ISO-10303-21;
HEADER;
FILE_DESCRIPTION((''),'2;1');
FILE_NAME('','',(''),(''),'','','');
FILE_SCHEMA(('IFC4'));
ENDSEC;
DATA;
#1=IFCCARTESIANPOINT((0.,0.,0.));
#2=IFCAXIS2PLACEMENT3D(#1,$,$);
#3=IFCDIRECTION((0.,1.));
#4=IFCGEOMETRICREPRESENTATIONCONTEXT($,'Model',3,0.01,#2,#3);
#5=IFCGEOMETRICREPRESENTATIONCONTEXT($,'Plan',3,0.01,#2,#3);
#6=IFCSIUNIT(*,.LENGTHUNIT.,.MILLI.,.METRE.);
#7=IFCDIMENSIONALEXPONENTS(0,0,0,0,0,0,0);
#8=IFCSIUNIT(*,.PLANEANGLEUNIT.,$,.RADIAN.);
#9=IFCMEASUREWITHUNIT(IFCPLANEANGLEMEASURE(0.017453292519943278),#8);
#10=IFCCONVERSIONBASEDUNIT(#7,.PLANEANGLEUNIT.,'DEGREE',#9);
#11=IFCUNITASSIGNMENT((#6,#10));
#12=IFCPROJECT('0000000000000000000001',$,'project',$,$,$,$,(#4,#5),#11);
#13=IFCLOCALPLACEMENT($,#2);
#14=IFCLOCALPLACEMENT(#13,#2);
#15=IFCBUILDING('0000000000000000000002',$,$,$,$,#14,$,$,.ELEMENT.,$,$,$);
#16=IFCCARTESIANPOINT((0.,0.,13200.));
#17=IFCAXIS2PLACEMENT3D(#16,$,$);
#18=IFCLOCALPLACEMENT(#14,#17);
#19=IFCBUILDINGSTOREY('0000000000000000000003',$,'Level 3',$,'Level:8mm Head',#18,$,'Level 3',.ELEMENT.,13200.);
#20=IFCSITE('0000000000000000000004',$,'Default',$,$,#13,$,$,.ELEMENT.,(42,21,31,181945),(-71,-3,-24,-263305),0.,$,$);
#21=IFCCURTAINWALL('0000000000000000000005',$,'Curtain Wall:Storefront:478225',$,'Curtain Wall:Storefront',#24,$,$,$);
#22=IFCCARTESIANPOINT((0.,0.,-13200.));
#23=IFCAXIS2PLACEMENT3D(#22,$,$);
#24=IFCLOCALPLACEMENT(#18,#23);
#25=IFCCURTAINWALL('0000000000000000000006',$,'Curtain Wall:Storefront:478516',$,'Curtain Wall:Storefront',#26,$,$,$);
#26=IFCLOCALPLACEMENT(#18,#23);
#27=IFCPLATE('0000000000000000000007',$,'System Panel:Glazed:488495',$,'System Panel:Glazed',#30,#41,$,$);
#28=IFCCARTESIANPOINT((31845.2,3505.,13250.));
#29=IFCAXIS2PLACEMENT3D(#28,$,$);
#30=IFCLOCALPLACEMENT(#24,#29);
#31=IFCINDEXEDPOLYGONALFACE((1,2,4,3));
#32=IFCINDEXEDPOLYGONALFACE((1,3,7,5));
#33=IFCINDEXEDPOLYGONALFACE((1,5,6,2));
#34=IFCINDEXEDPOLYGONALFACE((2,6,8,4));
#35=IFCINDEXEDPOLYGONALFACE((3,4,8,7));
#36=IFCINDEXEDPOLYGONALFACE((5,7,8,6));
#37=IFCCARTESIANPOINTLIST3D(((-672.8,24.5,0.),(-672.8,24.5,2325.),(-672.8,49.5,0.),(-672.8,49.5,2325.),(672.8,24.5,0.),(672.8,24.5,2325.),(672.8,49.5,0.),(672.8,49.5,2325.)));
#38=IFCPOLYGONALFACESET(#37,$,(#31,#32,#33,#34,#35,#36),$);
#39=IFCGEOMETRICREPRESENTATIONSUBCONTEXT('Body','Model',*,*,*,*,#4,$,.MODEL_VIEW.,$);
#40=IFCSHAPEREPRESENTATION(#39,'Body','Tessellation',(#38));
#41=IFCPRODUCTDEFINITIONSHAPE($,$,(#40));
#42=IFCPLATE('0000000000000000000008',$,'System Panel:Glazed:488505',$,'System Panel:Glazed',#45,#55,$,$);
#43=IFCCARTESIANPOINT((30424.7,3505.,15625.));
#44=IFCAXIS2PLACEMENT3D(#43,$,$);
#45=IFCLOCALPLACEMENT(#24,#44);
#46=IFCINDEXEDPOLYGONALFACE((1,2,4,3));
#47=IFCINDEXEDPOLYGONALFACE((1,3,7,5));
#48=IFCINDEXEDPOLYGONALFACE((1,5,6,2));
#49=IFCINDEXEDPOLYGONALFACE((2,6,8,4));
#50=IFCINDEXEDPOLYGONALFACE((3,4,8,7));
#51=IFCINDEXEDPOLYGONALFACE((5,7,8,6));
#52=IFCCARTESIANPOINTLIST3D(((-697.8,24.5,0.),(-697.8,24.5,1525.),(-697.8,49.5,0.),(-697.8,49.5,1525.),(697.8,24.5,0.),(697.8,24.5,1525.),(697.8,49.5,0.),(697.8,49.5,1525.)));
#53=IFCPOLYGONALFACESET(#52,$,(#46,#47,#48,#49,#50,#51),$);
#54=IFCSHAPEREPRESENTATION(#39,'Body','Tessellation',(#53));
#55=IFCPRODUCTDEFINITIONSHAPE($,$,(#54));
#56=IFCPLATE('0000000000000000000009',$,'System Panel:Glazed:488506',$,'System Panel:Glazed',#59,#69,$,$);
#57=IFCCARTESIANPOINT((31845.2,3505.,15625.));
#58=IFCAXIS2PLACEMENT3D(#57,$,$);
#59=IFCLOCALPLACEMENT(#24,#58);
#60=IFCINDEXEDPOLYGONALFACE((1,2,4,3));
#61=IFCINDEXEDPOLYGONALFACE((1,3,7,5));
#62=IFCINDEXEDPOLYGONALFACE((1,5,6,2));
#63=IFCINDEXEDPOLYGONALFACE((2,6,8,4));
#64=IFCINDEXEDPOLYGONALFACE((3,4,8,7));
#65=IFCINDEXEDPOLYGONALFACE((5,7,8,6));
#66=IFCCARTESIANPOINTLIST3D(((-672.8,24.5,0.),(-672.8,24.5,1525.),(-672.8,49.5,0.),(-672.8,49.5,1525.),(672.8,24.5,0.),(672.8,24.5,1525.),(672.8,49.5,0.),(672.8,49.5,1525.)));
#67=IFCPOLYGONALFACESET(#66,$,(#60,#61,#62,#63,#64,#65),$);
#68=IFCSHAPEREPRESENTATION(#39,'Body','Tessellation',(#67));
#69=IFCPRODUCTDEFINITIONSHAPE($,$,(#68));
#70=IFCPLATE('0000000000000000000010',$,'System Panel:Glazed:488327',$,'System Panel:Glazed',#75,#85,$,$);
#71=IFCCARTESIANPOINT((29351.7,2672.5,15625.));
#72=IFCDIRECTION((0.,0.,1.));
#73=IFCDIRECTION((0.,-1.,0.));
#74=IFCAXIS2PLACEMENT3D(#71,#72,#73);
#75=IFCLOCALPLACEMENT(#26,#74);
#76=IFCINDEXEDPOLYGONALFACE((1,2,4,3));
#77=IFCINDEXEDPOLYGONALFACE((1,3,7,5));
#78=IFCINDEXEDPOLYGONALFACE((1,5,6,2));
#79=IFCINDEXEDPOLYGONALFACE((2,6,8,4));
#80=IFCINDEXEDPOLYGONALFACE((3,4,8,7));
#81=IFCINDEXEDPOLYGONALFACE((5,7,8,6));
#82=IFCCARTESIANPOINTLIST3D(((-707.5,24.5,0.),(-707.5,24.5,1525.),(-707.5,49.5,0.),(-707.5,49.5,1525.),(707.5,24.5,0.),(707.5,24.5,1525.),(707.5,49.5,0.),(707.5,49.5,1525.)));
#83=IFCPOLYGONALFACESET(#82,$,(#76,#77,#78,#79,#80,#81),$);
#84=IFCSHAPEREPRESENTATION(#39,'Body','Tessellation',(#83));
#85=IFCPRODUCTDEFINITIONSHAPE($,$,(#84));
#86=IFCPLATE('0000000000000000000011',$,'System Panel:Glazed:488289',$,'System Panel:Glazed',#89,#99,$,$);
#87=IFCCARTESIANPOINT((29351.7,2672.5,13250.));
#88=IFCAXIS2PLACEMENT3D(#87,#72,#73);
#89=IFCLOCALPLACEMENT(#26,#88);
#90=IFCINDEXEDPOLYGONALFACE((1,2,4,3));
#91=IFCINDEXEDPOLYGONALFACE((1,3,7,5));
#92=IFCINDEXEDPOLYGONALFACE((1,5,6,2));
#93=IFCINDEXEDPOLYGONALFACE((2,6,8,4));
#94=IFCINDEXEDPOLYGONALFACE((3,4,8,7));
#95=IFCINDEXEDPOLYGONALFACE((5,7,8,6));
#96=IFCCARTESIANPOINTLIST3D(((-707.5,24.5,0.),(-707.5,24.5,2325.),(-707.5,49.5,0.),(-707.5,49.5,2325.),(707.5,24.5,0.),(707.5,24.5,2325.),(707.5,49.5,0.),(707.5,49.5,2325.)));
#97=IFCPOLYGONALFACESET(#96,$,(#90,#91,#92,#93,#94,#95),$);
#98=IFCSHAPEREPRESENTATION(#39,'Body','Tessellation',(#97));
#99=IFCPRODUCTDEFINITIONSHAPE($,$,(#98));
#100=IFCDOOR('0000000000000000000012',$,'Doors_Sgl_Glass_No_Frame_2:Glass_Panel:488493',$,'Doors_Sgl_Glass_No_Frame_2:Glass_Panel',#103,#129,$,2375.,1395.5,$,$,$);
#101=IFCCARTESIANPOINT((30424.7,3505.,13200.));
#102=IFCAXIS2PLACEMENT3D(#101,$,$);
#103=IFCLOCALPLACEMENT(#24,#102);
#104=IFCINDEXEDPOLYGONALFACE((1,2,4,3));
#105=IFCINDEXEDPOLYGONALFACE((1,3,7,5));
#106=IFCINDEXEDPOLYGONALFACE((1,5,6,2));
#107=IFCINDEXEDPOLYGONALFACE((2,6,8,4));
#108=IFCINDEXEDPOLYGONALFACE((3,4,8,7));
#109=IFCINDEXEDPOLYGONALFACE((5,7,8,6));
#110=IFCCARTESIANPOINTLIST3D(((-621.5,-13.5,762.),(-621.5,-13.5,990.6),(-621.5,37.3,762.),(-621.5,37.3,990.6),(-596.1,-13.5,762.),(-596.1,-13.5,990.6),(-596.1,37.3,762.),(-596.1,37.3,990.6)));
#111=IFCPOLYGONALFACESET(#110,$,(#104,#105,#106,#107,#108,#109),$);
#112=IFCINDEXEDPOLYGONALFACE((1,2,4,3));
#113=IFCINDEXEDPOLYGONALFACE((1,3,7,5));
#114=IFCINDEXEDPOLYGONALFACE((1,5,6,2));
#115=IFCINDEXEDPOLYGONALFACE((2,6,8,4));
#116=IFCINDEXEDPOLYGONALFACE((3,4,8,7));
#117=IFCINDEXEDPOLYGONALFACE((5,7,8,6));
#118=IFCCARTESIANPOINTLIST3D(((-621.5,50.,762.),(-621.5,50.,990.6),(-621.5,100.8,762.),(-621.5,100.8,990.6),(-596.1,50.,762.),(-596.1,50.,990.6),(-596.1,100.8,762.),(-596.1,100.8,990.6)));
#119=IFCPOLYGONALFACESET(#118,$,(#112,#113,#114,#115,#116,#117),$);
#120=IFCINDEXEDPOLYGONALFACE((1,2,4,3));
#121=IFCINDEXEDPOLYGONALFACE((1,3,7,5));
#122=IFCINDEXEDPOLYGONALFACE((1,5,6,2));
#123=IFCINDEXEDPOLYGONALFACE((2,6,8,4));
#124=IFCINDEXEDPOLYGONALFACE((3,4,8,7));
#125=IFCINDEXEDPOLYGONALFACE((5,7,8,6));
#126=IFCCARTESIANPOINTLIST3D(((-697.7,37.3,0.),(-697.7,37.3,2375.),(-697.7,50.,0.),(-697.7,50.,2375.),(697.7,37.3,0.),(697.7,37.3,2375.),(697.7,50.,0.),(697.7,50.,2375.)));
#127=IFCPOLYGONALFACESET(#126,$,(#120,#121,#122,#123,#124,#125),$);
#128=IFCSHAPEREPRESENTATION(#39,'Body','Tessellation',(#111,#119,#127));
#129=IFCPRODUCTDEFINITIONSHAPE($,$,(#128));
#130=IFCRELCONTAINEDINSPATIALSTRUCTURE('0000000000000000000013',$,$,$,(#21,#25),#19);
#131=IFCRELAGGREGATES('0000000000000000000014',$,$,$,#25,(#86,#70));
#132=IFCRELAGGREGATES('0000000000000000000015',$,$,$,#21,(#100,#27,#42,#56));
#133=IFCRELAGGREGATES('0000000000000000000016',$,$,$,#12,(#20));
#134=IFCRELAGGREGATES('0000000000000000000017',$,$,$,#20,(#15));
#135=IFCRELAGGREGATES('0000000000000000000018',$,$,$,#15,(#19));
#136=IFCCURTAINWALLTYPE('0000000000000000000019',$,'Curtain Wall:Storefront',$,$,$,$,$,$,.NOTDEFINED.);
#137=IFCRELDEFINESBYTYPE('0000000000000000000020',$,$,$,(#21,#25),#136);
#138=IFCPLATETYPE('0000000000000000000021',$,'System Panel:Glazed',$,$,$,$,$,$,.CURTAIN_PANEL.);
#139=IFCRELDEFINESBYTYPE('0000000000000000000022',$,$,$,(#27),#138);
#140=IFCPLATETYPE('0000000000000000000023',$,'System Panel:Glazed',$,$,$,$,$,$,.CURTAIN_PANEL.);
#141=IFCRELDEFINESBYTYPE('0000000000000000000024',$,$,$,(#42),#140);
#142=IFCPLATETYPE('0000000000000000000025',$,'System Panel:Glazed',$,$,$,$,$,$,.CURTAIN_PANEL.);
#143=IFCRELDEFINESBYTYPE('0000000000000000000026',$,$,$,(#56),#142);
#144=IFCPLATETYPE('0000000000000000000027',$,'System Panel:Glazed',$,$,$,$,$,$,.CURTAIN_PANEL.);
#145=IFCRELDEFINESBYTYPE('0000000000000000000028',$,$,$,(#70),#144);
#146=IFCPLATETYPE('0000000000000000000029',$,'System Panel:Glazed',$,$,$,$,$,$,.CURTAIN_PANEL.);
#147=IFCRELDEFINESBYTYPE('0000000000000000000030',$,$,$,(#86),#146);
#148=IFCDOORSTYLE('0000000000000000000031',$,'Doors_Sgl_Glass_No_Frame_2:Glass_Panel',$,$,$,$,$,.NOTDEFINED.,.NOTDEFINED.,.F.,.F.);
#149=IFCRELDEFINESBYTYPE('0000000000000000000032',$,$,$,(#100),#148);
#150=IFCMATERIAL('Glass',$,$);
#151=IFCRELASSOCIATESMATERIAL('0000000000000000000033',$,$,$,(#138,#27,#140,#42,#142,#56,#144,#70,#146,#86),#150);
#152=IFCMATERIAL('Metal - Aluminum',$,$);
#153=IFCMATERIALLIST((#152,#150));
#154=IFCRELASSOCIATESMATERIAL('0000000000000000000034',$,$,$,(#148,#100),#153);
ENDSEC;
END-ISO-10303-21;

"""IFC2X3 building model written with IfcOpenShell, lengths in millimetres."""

from ifc_helpers import new_model, entity, si_unit, converted_unit, direction, frame, frame_2d, origin, origin_2d_with_axis, place, context, subcontext, project, spatial, rectangle, extrude, source, transform, mapped, material, material_list, type_object, type_shapes, element, aggregate, save


model = new_model("IFC2X3")

# Units and contexts
model_context = context("Model", 3, precision=0.01, world=origin(), true_north=direction((0.0, 1.0)))
plan_context = context("Plan", 3, precision=0.01, world=origin(), true_north=direction((0.0, 1.0)))
body_context = subcontext(model_context, "Body", "Model", "MODEL_VIEW")
ifc_project = project(units=[si_unit("LENGTHUNIT", "METRE", prefix="MILLI"), converted_unit("PLANEANGLEUNIT", "DEGREE", entity("IfcPlaneAngleMeasure", 0.017453292519943278), si_unit("PLANEANGLEUNIT", "RADIAN"), dimensions=[0, 0, 0, 0, 0, 0, 0])], contexts=[model_context, plan_context])

# Site, building, storey
site_placement = place(None, origin())
site = spatial("IfcSite", under=ifc_project, at=site_placement, Name="Default", CompositionType="ELEMENT", RefLatitude=(42, 21, 31, 181945), RefLongitude=(-71, -3, -24, -263305), RefElevation=0.0)
building_placement = place(site_placement, origin())
building = spatial("IfcBuilding", under=site, at=building_placement, CompositionType="ELEMENT")
storey_placement = place(building_placement, frame((0.0, 0.0, 13200.0)))
storey = spatial("IfcBuildingStorey", under=building, at=storey_placement, Name="Level 3", ObjectType="Level:8mm Head", LongName="Level 3", CompositionType="ELEMENT", Elevation=13200.0)

# Curtain walls
curtain_wall_type = type_object("IfcCurtainWallType", Name="Curtain Wall:Storefront", PredefinedType="NOTDEFINED")
curtain_wall_1_placement = place(storey_placement, frame((0.0, 0.0, -13200.0)))
curtain_wall_1 = element("IfcCurtainWall", 1, at=curtain_wall_1_placement, inside=storey, type_object=curtain_wall_type, Name="Curtain Wall:Storefront:478225", ObjectType="Curtain Wall:Storefront")
curtain_wall_2_placement = place(storey_placement, frame((0.0, 0.0, -13200.0)))
curtain_wall_2 = element("IfcCurtainWall", 2, at=curtain_wall_2_placement, inside=storey, type_object=curtain_wall_type, Name="Curtain Wall:Storefront:478516", ObjectType="Curtain Wall:Storefront")

# Plates
ifc_material_1 = material(Name="Glass")
plate_type_1 = type_object("IfcPlateType", Name="System Panel:Glazed", PredefinedType="CURTAIN_PANEL", material=ifc_material_1)
shared_shape_1 = source(origin(), body_context, "Body", "SweptSolid", [
    extrude(rectangle(XDim=25.0, YDim=1345.5, at=origin_2d_with_axis()), frame((0.0, 37.0, 0.0), z_axis=(0.0, 0.0, 1.0), x_axis=(0.0, 1.0, 0.0)), (0.0, 0.0, 1.0), 2325.0),
])
type_shapes(plate_type_1, [shared_shape_1])
plate_1_placement = place(curtain_wall_1_placement, frame((31845.2, 3505.0, 13250.0)))
plate_1 = element("IfcPlate", 3, at=plate_1_placement, type_object=plate_type_1, material=ifc_material_1, Name="System Panel:Glazed:488495", ObjectType="System Panel:Glazed", context=body_context, shape_type="MappedRepresentation", body=[
    mapped(shared_shape_1, transform((0.0, 0.0, 0.0), scale=1.0)),
])
plate_type_2 = type_object("IfcPlateType", Name="System Panel:Glazed", PredefinedType="CURTAIN_PANEL", material=ifc_material_1)
shared_shape_2 = source(origin(), body_context, "Body", "SweptSolid", [
    extrude(rectangle(XDim=25.0, YDim=1395.5, at=origin_2d_with_axis()), frame((0.0, 37.0, 0.0), z_axis=(0.0, 0.0, 1.0), x_axis=(0.0, 1.0, 0.0)), (0.0, 0.0, 1.0), 1525.0),
])
type_shapes(plate_type_2, [shared_shape_2])
plate_2_placement = place(curtain_wall_1_placement, frame((30424.7, 3505.0, 15625.0)))
plate_2 = element("IfcPlate", 4, at=plate_2_placement, type_object=plate_type_2, material=ifc_material_1, Name="System Panel:Glazed:488505", ObjectType="System Panel:Glazed", context=body_context, shape_type="MappedRepresentation", body=[
    mapped(shared_shape_2, transform((0.0, 0.0, 0.0), scale=1.0)),
])
plate_type_3 = type_object("IfcPlateType", Name="System Panel:Glazed", PredefinedType="CURTAIN_PANEL", material=ifc_material_1)
shared_shape_3 = source(origin(), body_context, "Body", "SweptSolid", [
    extrude(rectangle(XDim=25.0, YDim=1345.5, at=origin_2d_with_axis()), frame((0.0, 37.0, 0.0), z_axis=(0.0, 0.0, 1.0), x_axis=(0.0, 1.0, 0.0)), (0.0, 0.0, 1.0), 1525.0),
])
type_shapes(plate_type_3, [shared_shape_3])
plate_3_placement = place(curtain_wall_1_placement, frame((31845.2, 3505.0, 15625.0)))
plate_3 = element("IfcPlate", 5, at=plate_3_placement, type_object=plate_type_3, material=ifc_material_1, Name="System Panel:Glazed:488506", ObjectType="System Panel:Glazed", context=body_context, shape_type="MappedRepresentation", body=[
    mapped(shared_shape_3, transform((0.0, 0.0, 0.0), scale=1.0)),
])
plate_type_4 = type_object("IfcPlateType", Name="System Panel:Glazed", PredefinedType="CURTAIN_PANEL", material=ifc_material_1)
shared_shape_4 = source(origin(), body_context, "Body", "SweptSolid", [
    extrude(rectangle(XDim=25.0, YDim=1415.0, at=origin_2d_with_axis()), frame((0.0, 37.0, 0.0), z_axis=(0.0, 0.0, 1.0), x_axis=(0.0, 1.0, 0.0)), (0.0, 0.0, 1.0), 1525.0),
])
type_shapes(plate_type_4, [shared_shape_4])
plate_4_placement = place(curtain_wall_2_placement, frame((29351.7, 2672.5, 15625.0), z_axis=(0.0, 0.0, 1.0), x_axis=(0.0, -1.0, 0.0)))
plate_4 = element("IfcPlate", 6, at=plate_4_placement, type_object=plate_type_4, material=ifc_material_1, Name="System Panel:Glazed:488327", ObjectType="System Panel:Glazed", context=body_context, shape_type="MappedRepresentation", body=[
    mapped(shared_shape_4, transform((0.0, 0.0, 0.0), scale=1.0)),
])
plate_type_5 = type_object("IfcPlateType", Name="System Panel:Glazed", PredefinedType="CURTAIN_PANEL", material=ifc_material_1)
shared_shape_5 = source(origin(), body_context, "Body", "SweptSolid", [
    extrude(rectangle(XDim=25.0, YDim=1415.0, at=origin_2d_with_axis()), frame((0.0, 37.0, 0.0), z_axis=(0.0, 0.0, 1.0), x_axis=(0.0, 1.0, 0.0)), (0.0, 0.0, 1.0), 2325.0),
])
type_shapes(plate_type_5, [shared_shape_5])
plate_5_placement = place(curtain_wall_2_placement, frame((29351.7, 2672.5, 13250.0), z_axis=(0.0, 0.0, 1.0), x_axis=(0.0, -1.0, 0.0)))
plate_5 = element("IfcPlate", 7, at=plate_5_placement, type_object=plate_type_5, material=ifc_material_1, Name="System Panel:Glazed:488289", ObjectType="System Panel:Glazed", context=body_context, shape_type="MappedRepresentation", body=[
    mapped(shared_shape_5, transform((0.0, 0.0, 0.0), scale=1.0)),
])
aggregate(curtain_wall_2, [plate_5, plate_4])

# Door
ifc_material_2 = material(Name="Metal - Aluminum")
ifc_material_list = material_list([ifc_material_2, ifc_material_1])
door_style = type_object("IfcDoorStyle", Name="Doors_Sgl_Glass_No_Frame_2:Glass_Panel", ConstructionType="NOTDEFINED", OperationType="NOTDEFINED", ParameterTakesPrecedence=False, Sizeable=False, material=ifc_material_list)
shared_shape_6 = source(origin(), body_context, "Body", "SweptSolid", [
    extrude(rectangle(XDim=50.8, YDim=25.4, at=origin_2d_with_axis()), frame((-608.8, 11.9, 762.0), z_axis=(0.0, 0.0, 1.0), x_axis=(0.0, 1.0, 0.0)), (0.0, 0.0, 1.0), 228.6),
    extrude(rectangle(XDim=50.8, YDim=25.4, at=origin_2d_with_axis()), frame((-608.8, 75.4, 762.0), z_axis=(0.0, 0.0, 1.0), x_axis=(0.0, -1.0, 0.0)), (0.0, 0.0, 1.0), 228.6),
    extrude(rectangle(XDim=1395.5, YDim=12.7, at=frame_2d((0.0, 0.0), x_axis=(1.0, 0.0))), frame((0.0, 43.7, 0.0), z_axis=(0.0, 0.0, 1.0), x_axis=(-1.0, 0.0, 0.0)), (0.0, 0.0, 1.0), 2375.0),
])
type_shapes(door_style, [shared_shape_6])
door_placement = place(curtain_wall_1_placement, frame((30424.7, 3505.0, 13200.0)))
door = element("IfcDoor", 8, at=door_placement, type_object=door_style, material=ifc_material_list, Name="Doors_Sgl_Glass_No_Frame_2:Glass_Panel:488493", ObjectType="Doors_Sgl_Glass_No_Frame_2:Glass_Panel", OverallHeight=2375.0, OverallWidth=1395.5, context=body_context, shape_type="MappedRepresentation", body=[
    mapped(shared_shape_6, transform((0.0, 0.0, 0.0), scale=1.0)),
])
aggregate(curtain_wall_1, [door, plate_1, plate_2, plate_3])

save(model, "model.ifc")
